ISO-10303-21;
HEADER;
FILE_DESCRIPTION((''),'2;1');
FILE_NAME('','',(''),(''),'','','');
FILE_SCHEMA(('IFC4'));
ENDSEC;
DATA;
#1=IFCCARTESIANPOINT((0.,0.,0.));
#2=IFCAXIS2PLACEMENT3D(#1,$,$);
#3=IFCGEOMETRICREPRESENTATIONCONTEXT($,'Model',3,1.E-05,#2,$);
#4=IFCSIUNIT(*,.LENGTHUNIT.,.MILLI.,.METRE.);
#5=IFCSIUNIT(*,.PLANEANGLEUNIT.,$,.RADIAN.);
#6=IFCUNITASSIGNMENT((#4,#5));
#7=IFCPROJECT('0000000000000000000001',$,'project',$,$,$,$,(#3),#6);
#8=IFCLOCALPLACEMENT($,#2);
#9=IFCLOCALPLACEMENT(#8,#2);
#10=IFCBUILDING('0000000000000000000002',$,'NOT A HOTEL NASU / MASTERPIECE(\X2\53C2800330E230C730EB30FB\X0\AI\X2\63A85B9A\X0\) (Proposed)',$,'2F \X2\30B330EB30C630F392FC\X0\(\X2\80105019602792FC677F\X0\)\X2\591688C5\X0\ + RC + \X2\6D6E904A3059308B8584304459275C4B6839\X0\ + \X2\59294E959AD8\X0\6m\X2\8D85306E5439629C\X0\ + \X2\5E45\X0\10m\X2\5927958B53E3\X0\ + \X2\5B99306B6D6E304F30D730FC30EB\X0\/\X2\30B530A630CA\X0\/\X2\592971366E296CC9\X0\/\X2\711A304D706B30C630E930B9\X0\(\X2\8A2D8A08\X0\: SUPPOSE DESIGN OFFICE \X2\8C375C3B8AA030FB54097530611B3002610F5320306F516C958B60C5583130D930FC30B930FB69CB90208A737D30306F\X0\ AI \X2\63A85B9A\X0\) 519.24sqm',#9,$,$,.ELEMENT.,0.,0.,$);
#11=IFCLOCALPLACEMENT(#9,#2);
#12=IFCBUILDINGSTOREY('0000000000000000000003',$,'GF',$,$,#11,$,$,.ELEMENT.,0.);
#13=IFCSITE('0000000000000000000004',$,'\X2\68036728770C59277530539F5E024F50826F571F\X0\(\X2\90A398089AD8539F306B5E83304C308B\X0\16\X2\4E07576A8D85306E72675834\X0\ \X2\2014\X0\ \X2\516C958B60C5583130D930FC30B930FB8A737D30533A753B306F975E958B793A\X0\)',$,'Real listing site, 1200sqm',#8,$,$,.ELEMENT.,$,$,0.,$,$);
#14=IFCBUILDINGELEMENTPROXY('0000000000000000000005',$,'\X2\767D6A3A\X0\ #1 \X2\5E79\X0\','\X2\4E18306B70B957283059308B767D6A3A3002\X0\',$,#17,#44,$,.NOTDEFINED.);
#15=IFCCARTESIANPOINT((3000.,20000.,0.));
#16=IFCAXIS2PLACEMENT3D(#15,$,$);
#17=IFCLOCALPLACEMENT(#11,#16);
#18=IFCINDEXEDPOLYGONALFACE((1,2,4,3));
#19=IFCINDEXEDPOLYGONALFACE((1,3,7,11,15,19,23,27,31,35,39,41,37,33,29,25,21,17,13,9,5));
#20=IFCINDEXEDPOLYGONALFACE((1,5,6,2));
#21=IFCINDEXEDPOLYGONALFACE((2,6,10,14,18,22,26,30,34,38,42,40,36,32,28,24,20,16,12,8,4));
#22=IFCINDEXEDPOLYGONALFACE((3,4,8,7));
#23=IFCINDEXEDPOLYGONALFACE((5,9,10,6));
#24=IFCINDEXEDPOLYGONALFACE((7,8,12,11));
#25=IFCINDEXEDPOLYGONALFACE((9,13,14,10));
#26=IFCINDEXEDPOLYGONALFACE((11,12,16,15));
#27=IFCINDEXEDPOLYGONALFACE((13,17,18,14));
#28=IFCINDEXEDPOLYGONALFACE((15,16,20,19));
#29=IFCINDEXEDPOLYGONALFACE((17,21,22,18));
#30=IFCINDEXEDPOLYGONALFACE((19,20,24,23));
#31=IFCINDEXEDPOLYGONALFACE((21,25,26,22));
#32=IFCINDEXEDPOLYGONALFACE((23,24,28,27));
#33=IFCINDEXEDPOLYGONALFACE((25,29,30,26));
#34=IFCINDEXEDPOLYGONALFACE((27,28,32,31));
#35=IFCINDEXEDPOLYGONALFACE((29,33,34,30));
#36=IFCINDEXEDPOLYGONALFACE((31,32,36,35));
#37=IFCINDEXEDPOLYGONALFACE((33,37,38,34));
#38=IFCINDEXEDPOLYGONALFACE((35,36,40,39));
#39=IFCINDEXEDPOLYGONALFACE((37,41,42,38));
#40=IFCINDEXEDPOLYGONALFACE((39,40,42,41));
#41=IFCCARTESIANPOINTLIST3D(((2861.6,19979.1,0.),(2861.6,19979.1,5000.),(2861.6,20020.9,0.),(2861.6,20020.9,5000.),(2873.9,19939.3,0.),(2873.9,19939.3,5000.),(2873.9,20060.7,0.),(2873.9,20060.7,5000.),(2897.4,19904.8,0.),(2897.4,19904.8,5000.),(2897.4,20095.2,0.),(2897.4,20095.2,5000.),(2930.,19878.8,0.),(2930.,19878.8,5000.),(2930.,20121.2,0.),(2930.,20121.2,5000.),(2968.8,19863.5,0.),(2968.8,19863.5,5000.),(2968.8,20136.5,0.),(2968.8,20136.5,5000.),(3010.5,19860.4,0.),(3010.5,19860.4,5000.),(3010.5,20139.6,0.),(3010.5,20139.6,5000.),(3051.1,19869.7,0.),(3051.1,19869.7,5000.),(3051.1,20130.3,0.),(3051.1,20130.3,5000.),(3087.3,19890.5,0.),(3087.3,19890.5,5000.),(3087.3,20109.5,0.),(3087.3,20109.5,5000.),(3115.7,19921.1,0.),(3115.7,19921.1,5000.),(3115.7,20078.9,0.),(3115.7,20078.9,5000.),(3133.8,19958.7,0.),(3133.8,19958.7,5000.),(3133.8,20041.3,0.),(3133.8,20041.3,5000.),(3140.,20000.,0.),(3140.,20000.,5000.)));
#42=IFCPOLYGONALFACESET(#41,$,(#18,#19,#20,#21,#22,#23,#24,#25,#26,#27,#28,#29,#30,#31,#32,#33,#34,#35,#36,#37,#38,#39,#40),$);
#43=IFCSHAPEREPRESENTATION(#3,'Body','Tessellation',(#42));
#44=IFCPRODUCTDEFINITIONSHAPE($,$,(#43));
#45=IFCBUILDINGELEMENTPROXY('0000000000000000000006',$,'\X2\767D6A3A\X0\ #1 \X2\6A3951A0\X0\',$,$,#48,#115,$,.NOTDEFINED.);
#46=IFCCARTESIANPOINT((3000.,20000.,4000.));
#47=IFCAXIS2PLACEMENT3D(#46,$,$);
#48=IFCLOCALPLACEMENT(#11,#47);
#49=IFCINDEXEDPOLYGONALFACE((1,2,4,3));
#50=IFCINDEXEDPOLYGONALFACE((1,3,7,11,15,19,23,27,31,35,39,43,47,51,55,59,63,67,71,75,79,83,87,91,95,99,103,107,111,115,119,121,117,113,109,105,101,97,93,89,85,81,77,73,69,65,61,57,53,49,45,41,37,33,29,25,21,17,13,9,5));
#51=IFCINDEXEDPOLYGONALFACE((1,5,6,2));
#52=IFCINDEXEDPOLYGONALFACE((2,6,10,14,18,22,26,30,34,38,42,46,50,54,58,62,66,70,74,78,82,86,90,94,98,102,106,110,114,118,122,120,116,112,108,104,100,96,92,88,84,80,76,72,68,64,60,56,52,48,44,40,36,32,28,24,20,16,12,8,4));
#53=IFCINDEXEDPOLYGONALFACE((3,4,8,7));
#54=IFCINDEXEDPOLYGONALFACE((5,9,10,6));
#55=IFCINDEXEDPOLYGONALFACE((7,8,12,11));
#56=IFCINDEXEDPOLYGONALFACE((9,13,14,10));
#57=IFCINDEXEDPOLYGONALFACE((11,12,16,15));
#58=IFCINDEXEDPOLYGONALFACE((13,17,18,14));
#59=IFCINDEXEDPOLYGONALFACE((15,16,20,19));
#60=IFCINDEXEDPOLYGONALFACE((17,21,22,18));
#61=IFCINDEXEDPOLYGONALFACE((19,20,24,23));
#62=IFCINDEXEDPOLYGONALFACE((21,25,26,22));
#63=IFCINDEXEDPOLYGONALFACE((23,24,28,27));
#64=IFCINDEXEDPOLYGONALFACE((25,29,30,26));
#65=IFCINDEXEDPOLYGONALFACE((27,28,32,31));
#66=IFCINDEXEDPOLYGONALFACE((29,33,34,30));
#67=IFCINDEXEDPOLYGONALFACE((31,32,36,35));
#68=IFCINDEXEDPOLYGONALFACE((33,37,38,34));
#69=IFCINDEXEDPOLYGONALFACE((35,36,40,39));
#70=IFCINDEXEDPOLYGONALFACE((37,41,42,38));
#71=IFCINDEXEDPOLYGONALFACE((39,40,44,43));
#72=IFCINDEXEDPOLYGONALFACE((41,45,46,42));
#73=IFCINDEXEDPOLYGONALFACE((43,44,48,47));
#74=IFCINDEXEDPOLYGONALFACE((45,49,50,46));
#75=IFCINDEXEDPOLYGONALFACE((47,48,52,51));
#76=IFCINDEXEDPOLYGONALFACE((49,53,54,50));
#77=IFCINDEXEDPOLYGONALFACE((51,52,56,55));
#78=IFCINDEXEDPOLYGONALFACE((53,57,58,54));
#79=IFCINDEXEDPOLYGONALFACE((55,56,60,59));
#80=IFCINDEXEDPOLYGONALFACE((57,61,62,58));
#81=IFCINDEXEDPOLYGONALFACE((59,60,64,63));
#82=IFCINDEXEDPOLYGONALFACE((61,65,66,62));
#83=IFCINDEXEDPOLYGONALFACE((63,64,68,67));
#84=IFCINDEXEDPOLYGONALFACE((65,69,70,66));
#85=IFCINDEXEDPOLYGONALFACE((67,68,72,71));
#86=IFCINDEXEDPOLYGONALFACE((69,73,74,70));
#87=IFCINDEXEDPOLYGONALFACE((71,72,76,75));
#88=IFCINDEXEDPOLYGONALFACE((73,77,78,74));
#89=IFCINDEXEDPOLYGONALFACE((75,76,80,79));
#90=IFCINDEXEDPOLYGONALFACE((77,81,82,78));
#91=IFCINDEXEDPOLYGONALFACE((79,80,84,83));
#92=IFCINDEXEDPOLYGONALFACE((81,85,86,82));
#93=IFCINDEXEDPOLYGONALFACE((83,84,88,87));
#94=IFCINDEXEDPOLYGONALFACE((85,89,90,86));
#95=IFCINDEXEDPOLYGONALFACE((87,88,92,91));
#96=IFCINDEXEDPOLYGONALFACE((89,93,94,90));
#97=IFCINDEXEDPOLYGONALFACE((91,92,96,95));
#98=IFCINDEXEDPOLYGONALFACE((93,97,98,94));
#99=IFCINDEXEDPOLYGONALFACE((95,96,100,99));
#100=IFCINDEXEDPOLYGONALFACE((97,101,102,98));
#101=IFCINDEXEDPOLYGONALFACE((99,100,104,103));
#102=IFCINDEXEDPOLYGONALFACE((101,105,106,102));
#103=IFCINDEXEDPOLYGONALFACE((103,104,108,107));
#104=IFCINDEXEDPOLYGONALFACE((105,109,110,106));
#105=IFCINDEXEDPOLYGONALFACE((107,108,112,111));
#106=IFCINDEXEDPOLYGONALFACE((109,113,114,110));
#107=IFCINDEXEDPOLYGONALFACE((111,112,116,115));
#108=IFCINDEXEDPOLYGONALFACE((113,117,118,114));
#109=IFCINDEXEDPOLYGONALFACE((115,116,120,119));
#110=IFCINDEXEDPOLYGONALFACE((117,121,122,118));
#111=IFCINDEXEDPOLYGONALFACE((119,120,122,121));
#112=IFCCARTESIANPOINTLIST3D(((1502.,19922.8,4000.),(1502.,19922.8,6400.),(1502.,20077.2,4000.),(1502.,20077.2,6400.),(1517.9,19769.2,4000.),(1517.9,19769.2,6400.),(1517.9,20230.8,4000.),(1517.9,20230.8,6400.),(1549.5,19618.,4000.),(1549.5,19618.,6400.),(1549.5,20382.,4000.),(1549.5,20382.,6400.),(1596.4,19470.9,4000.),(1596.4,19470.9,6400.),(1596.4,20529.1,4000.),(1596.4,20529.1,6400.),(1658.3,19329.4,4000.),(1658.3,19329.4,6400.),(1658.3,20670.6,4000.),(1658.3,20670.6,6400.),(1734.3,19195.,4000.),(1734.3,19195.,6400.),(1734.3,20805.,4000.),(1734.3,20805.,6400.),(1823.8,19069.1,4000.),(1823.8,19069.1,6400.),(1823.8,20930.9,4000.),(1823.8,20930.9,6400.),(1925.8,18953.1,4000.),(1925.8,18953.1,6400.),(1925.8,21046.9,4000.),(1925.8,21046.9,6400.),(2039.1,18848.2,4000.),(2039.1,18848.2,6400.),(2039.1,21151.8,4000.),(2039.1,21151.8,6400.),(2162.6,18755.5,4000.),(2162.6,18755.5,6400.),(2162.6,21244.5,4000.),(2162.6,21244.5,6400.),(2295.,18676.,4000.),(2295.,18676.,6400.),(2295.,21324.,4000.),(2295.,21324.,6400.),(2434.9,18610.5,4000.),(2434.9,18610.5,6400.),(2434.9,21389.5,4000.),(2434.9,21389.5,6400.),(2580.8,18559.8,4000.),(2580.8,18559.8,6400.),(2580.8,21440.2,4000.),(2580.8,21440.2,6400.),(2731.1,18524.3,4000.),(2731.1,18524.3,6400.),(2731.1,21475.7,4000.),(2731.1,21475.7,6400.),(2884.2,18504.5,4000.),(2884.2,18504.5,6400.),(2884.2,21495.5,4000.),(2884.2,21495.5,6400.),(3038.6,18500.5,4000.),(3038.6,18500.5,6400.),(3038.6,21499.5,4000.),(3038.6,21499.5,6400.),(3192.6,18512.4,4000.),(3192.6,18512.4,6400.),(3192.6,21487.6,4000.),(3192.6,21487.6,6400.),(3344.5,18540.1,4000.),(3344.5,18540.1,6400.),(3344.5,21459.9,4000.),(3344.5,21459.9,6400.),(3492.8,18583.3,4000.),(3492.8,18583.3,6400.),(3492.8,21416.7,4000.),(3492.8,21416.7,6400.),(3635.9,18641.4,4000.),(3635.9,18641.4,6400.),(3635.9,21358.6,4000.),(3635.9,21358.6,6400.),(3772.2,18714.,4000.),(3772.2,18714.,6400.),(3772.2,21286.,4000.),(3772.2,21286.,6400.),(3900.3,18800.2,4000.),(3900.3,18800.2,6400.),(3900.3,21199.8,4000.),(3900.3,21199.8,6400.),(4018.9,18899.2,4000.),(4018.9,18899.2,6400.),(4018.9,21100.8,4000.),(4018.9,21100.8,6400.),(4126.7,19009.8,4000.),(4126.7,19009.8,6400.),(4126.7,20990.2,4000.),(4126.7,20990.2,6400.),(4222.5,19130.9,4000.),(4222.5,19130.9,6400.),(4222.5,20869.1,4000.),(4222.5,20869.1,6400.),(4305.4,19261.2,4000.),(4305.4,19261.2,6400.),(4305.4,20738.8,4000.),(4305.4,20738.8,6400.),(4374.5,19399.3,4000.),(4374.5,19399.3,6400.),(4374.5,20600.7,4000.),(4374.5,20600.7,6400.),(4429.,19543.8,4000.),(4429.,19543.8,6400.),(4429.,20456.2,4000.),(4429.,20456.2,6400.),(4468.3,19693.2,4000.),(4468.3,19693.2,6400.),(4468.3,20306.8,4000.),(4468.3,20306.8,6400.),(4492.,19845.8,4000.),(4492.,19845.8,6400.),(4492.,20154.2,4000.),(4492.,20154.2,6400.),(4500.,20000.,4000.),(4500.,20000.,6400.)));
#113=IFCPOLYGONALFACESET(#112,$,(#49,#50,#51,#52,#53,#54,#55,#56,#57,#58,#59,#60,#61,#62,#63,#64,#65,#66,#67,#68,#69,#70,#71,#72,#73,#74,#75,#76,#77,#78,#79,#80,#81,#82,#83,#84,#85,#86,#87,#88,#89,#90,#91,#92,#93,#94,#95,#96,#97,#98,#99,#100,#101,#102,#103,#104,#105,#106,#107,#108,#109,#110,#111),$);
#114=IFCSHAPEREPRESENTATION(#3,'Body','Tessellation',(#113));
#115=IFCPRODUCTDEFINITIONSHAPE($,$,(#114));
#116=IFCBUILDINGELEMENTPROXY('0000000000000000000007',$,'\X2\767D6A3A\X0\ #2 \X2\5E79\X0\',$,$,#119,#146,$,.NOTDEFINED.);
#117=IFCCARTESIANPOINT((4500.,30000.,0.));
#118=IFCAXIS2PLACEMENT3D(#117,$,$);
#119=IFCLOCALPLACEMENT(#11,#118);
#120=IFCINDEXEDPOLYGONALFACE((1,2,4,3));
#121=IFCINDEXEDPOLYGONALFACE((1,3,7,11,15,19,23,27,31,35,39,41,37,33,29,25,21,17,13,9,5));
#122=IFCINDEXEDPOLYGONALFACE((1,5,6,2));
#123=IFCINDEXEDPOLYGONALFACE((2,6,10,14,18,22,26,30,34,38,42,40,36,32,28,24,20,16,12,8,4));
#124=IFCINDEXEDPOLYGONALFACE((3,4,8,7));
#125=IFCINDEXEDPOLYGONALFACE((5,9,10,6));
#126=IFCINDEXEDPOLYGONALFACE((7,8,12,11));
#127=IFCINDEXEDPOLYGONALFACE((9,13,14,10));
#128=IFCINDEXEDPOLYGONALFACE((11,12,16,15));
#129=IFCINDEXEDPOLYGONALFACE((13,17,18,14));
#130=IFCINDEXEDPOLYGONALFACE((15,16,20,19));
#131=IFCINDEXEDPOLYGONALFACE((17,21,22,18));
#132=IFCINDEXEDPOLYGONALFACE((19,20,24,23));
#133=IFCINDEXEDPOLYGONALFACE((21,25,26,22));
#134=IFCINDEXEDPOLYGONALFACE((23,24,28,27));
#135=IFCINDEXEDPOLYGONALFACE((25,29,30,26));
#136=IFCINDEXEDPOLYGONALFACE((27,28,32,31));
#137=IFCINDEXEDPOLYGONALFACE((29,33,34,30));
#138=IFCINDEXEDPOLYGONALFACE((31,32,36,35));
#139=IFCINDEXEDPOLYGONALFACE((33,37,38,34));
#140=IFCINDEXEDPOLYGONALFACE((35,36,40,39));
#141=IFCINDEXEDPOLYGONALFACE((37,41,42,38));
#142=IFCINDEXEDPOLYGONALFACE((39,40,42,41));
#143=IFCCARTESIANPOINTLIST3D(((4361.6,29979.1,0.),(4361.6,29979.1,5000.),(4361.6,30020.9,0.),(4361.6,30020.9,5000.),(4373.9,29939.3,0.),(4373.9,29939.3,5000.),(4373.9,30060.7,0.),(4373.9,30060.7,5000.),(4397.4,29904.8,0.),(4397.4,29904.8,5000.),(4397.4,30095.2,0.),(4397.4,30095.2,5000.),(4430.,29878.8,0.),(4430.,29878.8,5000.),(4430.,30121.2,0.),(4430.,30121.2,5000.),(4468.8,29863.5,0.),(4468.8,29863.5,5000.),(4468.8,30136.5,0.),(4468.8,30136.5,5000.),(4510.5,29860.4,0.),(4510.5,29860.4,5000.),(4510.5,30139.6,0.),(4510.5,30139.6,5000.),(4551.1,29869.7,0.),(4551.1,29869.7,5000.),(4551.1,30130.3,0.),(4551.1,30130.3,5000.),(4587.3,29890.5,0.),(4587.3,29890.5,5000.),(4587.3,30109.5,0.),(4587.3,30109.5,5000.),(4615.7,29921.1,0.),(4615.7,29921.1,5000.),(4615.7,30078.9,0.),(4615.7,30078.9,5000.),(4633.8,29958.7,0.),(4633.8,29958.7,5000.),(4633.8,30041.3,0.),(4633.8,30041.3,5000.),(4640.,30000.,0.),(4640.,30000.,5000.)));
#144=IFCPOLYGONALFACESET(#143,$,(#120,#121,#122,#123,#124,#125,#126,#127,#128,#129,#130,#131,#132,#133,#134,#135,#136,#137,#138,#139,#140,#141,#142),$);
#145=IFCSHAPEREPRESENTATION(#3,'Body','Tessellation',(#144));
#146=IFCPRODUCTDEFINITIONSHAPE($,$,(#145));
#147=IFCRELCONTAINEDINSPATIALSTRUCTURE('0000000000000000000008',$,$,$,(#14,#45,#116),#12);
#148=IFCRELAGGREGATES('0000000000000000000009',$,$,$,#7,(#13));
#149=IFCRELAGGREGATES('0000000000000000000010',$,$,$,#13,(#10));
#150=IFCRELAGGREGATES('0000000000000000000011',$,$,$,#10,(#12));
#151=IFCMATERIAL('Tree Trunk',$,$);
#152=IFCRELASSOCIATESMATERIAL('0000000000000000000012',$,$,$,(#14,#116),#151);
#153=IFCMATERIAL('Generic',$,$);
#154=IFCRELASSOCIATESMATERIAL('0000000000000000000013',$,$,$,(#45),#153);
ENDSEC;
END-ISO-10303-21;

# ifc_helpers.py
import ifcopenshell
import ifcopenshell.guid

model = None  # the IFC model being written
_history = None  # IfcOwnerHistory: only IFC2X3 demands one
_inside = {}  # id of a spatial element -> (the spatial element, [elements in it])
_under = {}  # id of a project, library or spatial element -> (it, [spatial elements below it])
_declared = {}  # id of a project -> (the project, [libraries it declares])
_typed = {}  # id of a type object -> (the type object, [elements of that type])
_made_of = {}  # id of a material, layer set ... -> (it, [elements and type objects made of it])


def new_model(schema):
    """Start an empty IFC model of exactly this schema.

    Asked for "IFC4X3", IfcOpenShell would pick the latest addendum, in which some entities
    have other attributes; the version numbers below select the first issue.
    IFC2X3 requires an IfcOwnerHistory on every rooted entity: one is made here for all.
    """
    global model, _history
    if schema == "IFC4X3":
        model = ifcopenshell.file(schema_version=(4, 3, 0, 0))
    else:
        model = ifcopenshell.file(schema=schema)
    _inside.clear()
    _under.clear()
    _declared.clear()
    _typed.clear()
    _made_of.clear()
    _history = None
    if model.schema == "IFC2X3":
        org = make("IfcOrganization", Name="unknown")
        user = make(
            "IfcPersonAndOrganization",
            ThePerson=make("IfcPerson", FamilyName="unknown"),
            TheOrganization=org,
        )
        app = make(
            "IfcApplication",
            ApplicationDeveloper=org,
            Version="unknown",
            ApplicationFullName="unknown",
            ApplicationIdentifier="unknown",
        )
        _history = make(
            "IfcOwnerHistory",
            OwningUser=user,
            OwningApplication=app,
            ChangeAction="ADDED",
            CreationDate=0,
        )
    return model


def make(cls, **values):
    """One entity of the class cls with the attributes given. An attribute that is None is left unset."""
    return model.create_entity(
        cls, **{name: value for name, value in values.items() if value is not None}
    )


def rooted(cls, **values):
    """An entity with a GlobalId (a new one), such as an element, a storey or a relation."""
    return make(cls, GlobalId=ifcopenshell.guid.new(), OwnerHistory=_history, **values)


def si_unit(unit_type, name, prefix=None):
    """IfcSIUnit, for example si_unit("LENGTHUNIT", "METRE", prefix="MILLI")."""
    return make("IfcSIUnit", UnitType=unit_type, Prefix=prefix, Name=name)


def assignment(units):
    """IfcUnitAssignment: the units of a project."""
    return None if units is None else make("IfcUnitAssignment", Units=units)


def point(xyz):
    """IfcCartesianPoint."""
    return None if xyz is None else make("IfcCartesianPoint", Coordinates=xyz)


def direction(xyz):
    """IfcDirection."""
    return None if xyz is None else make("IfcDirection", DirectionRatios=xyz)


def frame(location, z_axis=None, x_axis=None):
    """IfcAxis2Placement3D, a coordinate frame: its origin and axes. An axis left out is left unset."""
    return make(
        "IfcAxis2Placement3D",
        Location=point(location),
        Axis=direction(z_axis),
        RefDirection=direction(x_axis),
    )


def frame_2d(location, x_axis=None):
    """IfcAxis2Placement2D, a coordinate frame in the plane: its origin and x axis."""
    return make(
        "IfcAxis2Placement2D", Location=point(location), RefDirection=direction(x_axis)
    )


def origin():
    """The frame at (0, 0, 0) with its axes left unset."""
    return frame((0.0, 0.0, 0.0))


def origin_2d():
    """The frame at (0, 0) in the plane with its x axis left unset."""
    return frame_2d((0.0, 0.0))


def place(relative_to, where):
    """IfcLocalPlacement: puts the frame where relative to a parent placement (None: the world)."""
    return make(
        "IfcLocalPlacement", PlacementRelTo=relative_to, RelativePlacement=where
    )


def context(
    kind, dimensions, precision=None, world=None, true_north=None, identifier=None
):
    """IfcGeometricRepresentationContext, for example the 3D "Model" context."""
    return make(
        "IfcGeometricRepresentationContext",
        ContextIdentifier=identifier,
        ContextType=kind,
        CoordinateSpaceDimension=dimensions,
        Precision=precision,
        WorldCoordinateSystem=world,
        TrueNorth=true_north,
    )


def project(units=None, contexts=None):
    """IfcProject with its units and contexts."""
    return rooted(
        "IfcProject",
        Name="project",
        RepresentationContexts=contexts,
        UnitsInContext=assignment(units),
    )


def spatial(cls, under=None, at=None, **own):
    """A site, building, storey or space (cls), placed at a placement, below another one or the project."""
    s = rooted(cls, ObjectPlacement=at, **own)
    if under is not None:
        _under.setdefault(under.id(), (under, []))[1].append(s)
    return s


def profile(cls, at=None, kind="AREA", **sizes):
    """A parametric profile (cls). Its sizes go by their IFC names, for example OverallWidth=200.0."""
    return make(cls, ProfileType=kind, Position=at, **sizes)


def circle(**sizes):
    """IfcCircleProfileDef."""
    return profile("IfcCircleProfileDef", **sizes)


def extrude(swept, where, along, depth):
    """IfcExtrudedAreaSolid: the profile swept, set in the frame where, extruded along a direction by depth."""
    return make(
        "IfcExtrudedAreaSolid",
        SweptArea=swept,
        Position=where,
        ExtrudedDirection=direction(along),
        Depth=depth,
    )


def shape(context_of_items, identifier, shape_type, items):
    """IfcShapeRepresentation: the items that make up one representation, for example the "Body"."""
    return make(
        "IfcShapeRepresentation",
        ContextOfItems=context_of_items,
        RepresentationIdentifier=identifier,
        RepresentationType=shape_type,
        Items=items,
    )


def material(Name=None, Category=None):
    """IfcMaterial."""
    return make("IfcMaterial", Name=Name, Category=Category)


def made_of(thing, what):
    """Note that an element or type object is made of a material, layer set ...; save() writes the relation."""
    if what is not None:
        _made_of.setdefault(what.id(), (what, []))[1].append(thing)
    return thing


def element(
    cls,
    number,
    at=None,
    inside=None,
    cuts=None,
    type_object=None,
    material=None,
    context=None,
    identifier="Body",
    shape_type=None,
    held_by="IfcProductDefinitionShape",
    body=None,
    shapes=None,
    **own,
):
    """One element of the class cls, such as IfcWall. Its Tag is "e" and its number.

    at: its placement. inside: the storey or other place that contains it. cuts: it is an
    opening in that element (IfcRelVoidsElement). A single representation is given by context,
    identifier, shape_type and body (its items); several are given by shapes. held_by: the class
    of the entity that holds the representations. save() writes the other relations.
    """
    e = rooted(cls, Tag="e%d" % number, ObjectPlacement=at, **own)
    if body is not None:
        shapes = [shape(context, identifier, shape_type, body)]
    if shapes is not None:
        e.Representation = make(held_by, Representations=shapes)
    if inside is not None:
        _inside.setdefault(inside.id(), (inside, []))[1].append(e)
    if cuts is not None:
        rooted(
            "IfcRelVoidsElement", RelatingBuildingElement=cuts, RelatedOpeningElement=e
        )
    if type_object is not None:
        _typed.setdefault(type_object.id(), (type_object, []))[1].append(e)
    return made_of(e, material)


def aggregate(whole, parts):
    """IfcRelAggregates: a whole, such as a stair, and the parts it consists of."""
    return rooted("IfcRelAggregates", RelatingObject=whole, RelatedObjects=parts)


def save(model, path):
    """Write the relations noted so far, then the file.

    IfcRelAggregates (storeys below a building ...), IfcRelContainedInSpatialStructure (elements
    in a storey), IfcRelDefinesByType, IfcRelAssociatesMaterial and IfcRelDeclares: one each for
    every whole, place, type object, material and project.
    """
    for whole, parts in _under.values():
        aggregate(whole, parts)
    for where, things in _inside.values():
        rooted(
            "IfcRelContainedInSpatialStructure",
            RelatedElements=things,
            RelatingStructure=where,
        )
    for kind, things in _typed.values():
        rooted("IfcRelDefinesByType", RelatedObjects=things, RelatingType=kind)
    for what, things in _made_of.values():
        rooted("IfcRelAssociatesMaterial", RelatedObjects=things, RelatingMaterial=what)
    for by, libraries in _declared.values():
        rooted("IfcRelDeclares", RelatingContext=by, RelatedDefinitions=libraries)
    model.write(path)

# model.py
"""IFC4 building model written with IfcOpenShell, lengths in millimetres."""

from ifc_helpers import new_model, si_unit, frame, origin, origin_2d, place, context, project, spatial, circle, extrude, material, element, save


model = new_model("IFC4")

# Units and contexts
model_context = context("Model", 3, precision=1e-05, world=origin())
ifc_project = project(units=[si_unit("LENGTHUNIT", "METRE", prefix="MILLI"), si_unit("PLANEANGLEUNIT", "RADIAN")], contexts=[model_context])

# Site, building, storey
site_placement = place(None, origin())
site = spatial("IfcSite", under=ifc_project, at=site_placement, Name="栃木県大田原市佐良土(那須高原に広がる16万坪超の牧場 — 公開情報ベース・詳細区画は非開示)", ObjectType="Real listing site, 1200sqm", CompositionType="ELEMENT", RefElevation=0.0)
building_placement = place(site_placement, origin())
building = spatial("IfcBuilding", under=site, at=building_placement, Name="NOT A HOTEL NASU / MASTERPIECE(参考モデル・AI推定) (Proposed)", ObjectType="2F コルテン鋼(耐候性鋼板)外装 + RC + 浮遊する薄い大屋根 + 天井高6m超の吹抜 + 幅10m大開口 + 宙に浮くプール/サウナ/天然温泉/焚き火テラス(設計: SUPPOSE DESIGN OFFICE 谷尻誠・吉田愛。意匠は公開情報ベース・構造詳細は AI 推定) 519.24sqm", CompositionType="ELEMENT", ElevationOfRefHeight=0.0, ElevationOfTerrain=0.0)
storey_placement = place(building_placement, origin())
storey = spatial("IfcBuildingStorey", under=building, at=storey_placement, Name="GF", CompositionType="ELEMENT", Elevation=0.0)

# Shared definitions
ifc_material_1 = material(Name="Generic")

# Building element proxies
ifc_material_2 = material(Name="Tree Trunk")
proxy_1_placement = place(storey_placement, frame((3000.0, 20000.0, 0.0)))
element("IfcBuildingElementProxy", 1, at=proxy_1_placement, inside=storey, material=ifc_material_2, Name="白樺 #1 幹", Description="丘に点在する白樺。", PredefinedType="NOTDEFINED", context=model_context, shape_type="SweptSolid", body=[
    extrude(circle(Radius=140.0, at=origin_2d()), frame((3000.0, 20000.0, 0.0)), (0.0, 0.0, 1.0), 5000.0),
])
proxy_2_placement = place(storey_placement, frame((3000.0, 20000.0, 4000.0)))
element("IfcBuildingElementProxy", 2, at=proxy_2_placement, inside=storey, material=ifc_material_1, Name="白樺 #1 樹冠", PredefinedType="NOTDEFINED", context=model_context, shape_type="SweptSolid", body=[
    extrude(circle(Radius=1500.0, at=origin_2d()), frame((3000.0, 20000.0, 4000.0)), (0.0, 0.0, 1.0), 2400.0),
])
proxy_3_placement = place(storey_placement, frame((4500.0, 30000.0, 0.0)))
element("IfcBuildingElementProxy", 3, at=proxy_3_placement, inside=storey, material=ifc_material_2, Name="白樺 #2 幹", PredefinedType="NOTDEFINED", context=model_context, shape_type="SweptSolid", body=[
    extrude(circle(Radius=140.0, at=origin_2d()), frame((4500.0, 30000.0, 0.0)), (0.0, 0.0, 1.0), 5000.0),
])

save(model, "model.ifc")
